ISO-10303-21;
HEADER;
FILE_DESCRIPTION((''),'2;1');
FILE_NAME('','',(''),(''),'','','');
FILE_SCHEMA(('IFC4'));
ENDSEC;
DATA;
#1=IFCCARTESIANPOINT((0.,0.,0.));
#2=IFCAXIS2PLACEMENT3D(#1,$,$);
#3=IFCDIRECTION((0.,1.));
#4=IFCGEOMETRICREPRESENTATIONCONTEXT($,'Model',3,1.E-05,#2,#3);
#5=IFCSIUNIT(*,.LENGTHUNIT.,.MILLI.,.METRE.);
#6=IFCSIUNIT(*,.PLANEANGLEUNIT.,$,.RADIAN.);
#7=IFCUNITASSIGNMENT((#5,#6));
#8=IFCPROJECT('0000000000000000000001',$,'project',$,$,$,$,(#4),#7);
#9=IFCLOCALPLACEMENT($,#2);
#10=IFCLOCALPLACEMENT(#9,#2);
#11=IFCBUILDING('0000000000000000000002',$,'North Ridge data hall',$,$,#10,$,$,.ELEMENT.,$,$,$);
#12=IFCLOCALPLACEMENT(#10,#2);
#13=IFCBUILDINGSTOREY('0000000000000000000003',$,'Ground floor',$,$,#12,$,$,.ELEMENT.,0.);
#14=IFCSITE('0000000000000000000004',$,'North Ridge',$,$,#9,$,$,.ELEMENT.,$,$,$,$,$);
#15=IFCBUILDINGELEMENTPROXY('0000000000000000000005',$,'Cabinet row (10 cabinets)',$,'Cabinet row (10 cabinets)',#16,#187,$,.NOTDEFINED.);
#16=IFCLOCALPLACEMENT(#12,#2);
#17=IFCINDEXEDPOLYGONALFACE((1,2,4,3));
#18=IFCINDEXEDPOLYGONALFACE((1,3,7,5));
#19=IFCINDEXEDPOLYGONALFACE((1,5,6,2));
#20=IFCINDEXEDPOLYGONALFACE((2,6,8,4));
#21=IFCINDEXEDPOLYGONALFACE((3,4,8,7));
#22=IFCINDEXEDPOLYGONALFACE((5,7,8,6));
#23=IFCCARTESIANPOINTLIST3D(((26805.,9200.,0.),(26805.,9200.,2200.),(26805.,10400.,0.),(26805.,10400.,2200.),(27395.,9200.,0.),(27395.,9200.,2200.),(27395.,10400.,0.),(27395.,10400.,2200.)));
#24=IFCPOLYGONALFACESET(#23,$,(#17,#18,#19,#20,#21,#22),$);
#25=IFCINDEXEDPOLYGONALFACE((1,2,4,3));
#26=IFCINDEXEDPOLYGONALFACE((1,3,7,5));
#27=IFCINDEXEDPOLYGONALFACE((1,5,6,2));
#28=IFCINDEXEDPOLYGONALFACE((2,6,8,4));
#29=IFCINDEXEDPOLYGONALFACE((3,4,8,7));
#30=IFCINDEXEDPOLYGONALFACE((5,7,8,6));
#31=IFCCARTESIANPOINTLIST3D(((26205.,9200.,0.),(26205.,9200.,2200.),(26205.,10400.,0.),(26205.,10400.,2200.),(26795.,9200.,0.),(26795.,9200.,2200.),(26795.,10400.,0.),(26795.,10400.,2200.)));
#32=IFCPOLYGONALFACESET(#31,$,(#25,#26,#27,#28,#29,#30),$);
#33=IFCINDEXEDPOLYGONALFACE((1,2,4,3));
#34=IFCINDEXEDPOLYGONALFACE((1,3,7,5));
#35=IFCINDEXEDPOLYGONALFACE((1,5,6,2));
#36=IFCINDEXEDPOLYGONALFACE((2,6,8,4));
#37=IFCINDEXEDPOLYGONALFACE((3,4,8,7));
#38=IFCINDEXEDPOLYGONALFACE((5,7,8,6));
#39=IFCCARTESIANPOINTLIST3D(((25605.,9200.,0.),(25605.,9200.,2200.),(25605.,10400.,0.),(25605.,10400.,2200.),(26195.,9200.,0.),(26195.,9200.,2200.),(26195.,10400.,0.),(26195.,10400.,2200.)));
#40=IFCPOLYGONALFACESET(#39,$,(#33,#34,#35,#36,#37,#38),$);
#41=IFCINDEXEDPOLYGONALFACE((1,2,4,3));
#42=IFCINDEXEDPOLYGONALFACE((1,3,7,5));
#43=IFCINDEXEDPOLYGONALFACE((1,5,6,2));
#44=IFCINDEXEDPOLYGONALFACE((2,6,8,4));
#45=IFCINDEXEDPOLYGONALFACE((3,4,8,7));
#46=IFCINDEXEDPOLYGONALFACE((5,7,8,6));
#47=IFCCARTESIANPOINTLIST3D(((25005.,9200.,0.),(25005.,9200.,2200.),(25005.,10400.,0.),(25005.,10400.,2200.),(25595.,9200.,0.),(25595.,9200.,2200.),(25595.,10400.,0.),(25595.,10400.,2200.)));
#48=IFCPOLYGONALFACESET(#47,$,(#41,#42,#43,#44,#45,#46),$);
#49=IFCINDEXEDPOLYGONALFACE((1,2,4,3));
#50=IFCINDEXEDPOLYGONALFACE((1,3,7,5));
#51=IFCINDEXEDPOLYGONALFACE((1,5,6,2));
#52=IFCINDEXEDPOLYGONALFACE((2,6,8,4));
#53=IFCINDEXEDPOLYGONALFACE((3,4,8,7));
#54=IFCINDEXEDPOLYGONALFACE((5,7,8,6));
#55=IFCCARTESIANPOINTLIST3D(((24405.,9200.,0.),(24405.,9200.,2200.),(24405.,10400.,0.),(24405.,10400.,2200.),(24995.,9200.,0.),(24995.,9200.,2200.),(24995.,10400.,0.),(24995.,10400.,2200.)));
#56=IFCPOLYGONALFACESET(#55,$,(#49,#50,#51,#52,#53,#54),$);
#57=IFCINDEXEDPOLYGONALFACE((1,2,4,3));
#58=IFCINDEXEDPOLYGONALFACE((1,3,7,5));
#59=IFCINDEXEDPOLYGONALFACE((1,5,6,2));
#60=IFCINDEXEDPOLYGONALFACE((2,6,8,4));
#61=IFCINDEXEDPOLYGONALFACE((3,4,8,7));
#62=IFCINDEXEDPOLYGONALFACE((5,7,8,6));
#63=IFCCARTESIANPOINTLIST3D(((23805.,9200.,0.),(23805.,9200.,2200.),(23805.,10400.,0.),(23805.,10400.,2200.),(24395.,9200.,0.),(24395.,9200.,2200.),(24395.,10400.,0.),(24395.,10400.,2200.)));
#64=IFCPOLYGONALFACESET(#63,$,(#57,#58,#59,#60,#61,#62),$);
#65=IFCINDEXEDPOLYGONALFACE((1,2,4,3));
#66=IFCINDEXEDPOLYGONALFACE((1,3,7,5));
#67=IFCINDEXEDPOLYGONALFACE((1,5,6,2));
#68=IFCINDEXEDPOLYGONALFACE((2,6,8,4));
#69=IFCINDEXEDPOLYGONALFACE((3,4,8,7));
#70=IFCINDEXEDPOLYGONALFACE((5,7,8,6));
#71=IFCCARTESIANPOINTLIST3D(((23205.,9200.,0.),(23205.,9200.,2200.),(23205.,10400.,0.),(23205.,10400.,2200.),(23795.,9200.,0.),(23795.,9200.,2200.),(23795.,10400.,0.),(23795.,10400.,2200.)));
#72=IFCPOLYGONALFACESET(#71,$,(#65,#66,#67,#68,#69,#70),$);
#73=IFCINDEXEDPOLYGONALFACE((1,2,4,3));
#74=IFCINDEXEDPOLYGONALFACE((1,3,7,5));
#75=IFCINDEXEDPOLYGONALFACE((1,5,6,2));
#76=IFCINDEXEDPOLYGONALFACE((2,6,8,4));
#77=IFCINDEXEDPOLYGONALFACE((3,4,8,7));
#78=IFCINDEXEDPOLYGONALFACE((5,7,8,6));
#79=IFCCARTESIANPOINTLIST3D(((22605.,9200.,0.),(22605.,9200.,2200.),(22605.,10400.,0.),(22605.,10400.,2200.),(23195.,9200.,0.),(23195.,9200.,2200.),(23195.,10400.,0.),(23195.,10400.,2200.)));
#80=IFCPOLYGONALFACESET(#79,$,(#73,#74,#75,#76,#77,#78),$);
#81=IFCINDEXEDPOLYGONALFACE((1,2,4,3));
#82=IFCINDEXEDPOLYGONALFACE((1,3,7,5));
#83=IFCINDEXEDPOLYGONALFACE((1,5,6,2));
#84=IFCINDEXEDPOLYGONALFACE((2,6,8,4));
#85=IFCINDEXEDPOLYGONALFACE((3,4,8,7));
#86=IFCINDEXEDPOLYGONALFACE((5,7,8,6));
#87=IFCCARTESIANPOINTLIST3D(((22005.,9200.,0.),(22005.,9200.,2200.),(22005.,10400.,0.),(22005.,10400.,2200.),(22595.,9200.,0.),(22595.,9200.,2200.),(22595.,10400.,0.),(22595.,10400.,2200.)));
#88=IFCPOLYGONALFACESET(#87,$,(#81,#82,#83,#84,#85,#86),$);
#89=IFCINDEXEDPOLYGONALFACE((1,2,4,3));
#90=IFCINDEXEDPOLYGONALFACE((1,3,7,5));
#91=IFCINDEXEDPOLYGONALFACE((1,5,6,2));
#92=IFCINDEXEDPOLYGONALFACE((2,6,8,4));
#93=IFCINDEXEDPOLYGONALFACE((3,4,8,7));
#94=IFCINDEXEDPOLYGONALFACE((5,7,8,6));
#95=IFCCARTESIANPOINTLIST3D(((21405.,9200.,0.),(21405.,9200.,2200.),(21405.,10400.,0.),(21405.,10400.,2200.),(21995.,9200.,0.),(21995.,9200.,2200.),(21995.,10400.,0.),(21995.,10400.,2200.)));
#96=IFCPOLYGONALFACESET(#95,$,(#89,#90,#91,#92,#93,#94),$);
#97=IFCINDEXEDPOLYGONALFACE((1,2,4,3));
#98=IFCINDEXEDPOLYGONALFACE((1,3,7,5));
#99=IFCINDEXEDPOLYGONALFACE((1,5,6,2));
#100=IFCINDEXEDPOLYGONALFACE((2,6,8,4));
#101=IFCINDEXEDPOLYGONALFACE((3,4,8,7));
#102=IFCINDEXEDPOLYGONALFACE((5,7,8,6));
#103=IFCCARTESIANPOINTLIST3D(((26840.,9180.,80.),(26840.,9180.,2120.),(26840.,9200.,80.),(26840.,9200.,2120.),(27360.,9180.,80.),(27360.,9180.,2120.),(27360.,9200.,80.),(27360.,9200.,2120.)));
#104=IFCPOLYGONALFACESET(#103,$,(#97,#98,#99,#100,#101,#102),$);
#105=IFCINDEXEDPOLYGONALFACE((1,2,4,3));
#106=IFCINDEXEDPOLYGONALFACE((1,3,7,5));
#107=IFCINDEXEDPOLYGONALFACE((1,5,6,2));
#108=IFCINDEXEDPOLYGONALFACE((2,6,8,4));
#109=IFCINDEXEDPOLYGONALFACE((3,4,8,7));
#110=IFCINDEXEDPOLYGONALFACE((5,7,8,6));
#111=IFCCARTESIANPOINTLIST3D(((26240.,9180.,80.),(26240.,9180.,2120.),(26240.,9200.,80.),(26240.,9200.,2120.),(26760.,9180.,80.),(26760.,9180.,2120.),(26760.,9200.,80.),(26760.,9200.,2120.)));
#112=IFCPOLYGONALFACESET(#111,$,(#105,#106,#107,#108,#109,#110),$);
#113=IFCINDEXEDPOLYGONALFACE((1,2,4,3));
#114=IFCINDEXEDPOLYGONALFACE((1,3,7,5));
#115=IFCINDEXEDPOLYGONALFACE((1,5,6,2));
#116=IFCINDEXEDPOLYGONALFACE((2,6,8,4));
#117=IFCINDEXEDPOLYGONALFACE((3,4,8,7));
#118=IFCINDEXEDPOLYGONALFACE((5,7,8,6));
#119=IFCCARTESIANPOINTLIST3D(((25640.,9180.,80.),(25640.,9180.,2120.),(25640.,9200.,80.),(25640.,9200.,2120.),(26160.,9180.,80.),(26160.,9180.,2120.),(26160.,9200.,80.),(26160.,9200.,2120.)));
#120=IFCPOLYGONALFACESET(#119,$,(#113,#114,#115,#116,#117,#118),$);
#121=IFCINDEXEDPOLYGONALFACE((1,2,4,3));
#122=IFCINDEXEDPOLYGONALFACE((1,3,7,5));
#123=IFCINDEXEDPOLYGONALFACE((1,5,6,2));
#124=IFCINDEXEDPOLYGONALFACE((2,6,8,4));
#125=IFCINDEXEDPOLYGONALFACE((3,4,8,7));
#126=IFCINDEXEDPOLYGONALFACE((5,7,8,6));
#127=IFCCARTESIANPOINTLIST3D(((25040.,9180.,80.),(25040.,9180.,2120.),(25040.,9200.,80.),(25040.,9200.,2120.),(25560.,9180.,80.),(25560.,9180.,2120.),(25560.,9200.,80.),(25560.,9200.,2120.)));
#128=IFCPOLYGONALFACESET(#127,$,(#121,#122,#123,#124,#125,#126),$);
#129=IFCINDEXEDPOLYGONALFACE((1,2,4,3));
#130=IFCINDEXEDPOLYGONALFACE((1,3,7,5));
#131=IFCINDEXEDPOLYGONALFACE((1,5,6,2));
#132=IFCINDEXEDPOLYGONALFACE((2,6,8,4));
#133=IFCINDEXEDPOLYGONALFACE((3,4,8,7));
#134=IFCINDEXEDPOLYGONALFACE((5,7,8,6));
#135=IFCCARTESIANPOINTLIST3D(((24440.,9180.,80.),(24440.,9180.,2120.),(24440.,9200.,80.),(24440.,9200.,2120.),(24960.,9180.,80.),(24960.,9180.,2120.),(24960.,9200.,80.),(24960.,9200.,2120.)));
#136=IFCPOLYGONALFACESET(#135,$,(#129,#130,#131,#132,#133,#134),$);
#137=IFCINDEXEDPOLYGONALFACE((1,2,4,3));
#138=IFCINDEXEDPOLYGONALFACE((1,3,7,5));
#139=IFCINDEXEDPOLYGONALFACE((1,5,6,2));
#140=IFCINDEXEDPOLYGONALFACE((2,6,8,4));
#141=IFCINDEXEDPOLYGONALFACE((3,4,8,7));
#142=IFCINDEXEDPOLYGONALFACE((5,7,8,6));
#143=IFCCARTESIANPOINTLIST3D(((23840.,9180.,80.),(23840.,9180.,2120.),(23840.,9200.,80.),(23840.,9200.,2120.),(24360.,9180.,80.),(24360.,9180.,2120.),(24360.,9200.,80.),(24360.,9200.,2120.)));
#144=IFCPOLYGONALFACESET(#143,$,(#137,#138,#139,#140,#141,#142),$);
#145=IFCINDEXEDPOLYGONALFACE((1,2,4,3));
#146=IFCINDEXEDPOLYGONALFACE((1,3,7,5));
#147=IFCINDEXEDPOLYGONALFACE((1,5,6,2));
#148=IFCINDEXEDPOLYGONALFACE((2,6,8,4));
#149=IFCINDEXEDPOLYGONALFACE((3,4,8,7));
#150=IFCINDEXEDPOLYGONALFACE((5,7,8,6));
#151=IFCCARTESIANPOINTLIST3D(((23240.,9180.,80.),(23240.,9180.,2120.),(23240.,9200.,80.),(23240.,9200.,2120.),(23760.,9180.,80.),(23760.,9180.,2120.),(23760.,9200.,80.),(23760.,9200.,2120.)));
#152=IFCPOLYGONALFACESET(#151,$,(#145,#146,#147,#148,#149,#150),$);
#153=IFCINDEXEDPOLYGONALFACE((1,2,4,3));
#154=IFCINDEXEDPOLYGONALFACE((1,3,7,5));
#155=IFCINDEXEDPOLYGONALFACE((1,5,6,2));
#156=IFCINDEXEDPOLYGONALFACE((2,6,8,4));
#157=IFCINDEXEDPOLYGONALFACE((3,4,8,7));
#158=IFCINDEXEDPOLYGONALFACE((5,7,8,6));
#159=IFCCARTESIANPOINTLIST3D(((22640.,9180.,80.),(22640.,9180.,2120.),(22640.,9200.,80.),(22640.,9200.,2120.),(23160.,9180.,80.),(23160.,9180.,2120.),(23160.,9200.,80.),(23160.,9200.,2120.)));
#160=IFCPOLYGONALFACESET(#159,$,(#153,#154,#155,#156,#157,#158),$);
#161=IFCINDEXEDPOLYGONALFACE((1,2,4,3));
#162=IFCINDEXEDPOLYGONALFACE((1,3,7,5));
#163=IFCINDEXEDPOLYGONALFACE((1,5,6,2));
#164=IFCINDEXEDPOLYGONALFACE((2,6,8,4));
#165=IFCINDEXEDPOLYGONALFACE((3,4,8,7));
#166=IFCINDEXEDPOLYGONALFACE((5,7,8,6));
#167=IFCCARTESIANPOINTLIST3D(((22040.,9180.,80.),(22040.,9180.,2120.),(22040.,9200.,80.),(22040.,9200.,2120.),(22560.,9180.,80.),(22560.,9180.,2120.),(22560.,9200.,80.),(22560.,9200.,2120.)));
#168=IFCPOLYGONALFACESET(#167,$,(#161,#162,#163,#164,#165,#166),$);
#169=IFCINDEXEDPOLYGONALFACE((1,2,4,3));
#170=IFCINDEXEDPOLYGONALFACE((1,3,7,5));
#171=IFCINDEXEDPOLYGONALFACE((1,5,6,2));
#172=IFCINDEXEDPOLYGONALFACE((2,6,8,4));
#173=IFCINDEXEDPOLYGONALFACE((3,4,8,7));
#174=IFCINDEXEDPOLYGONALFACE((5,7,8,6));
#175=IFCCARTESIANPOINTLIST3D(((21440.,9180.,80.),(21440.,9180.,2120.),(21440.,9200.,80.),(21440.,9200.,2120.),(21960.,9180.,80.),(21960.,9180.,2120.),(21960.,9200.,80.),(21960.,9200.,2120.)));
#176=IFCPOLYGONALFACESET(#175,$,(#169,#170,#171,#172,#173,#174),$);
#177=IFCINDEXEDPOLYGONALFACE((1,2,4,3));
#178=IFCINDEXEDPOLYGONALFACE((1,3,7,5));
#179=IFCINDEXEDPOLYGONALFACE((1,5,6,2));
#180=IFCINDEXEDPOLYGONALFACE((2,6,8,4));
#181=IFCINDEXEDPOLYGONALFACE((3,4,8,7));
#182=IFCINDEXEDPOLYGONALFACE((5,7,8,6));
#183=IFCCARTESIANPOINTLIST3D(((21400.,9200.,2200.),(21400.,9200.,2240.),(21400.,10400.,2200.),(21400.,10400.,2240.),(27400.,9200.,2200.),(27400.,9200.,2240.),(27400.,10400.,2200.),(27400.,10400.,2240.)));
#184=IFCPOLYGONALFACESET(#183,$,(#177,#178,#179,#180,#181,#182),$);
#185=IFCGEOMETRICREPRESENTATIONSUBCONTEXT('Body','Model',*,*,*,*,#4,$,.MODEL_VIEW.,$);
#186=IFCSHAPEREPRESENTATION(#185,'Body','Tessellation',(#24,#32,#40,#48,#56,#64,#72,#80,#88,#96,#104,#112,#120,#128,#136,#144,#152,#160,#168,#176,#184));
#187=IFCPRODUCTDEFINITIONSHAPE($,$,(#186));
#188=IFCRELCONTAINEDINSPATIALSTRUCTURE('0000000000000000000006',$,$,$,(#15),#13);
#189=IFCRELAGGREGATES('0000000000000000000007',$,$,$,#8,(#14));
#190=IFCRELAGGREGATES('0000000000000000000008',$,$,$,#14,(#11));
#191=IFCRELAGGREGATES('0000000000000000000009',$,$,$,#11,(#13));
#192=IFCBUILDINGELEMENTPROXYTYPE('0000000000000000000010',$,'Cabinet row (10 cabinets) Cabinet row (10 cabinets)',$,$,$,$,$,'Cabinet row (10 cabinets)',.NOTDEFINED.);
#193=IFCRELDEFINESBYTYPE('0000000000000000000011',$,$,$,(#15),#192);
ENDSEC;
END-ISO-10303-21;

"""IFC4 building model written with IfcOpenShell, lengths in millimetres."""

from ifc_helpers import new_model, si_unit, direction, frame, origin, place, context, subcontext, project, spatial, polyline, outline, extrude, source, transform, mapped, type_object, type_shapes, element, save


model = new_model("IFC4")

# Units and contexts
model_context = context("Model", 3, precision=1e-05, world=origin(), true_north=direction((0.0, 1.0)))
body_context = subcontext(model_context, "Body", "Model", "MODEL_VIEW")
ifc_project = project(units=[si_unit("LENGTHUNIT", "METRE", prefix="MILLI"), si_unit("PLANEANGLEUNIT", "RADIAN")], contexts=[model_context])

# Site, building, storey
site_placement = place(None, origin())
site = spatial("IfcSite", under=ifc_project, at=site_placement, Name="North Ridge", CompositionType="ELEMENT")
building_placement = place(site_placement, origin())
building = spatial("IfcBuilding", under=site, at=building_placement, Name="North Ridge data hall", CompositionType="ELEMENT")
storey_placement = place(building_placement, origin())
storey = spatial("IfcBuildingStorey", under=building, at=storey_placement, Name="Ground floor", CompositionType="ELEMENT", Elevation=0.0)

# Building element proxy
building_element_proxy_type_1 = type_object("IfcBuildingElementProxyType", Name="Cabinet row (10 cabinets) Cabinet row (10 cabinets)", ElementType="Cabinet row (10 cabinets)", PredefinedType="NOTDEFINED")
shared_shape_1 = source(origin(), body_context, "Body", "SweptSolid", [
    extrude(outline(polyline([(5.0, 0.0), (595.0, 0.0), (595.0, 1200.0), (5.0, 1200.0), (5.0, 0.0)])), origin(), (0.0, 0.0, 1.0), 2200.0),
    extrude(outline(polyline([(605.0, 0.0), (1195.0, 0.0), (1195.0, 1200.0), (605.0, 1200.0), (605.0, 0.0)])), origin(), (0.0, 0.0, 1.0), 2200.0),
    extrude(outline(polyline([(1205.0, 0.0), (1795.0, 0.0), (1795.0, 1200.0), (1205.0, 1200.0), (1205.0, 0.0)])), origin(), (0.0, 0.0, 1.0), 2200.0),
    extrude(outline(polyline([(1805.0, 0.0), (2395.0, 0.0), (2395.0, 1200.0), (1805.0, 1200.0), (1805.0, 0.0)])), origin(), (0.0, 0.0, 1.0), 2200.0),
    extrude(outline(polyline([(2405.0, 0.0), (2995.0, 0.0), (2995.0, 1200.0), (2405.0, 1200.0), (2405.0, 0.0)])), origin(), (0.0, 0.0, 1.0), 2200.0),
    extrude(outline(polyline([(3005.0, 0.0), (3595.0, 0.0), (3595.0, 1200.0), (3005.0, 1200.0), (3005.0, 0.0)])), origin(), (0.0, 0.0, 1.0), 2200.0),
    extrude(outline(polyline([(3605.0, 0.0), (4195.0, 0.0), (4195.0, 1200.0), (3605.0, 1200.0), (3605.0, 0.0)])), origin(), (0.0, 0.0, 1.0), 2200.0),
    extrude(outline(polyline([(4205.0, 0.0), (4795.0, 0.0), (4795.0, 1200.0), (4205.0, 1200.0), (4205.0, 0.0)])), origin(), (0.0, 0.0, 1.0), 2200.0),
    extrude(outline(polyline([(4805.0, 0.0), (5395.0, 0.0), (5395.0, 1200.0), (4805.0, 1200.0), (4805.0, 0.0)])), origin(), (0.0, 0.0, 1.0), 2200.0),
    extrude(outline(polyline([(5405.0, 0.0), (5995.0, 0.0), (5995.0, 1200.0), (5405.0, 1200.0), (5405.0, 0.0)])), origin(), (0.0, 0.0, 1.0), 2200.0),
    extrude(outline(polyline([(40.0, 1200.0), (560.0, 1200.0), (560.0, 1220.0), (40.0, 1220.0), (40.0, 1200.0)])), frame((0.0, 0.0, 80.0)), (0.0, 0.0, 1.0), 2040.0),
    extrude(outline(polyline([(640.0, 1200.0), (1160.0, 1200.0), (1160.0, 1220.0), (640.0, 1220.0), (640.0, 1200.0)])), frame((0.0, 0.0, 80.0)), (0.0, 0.0, 1.0), 2040.0),
    extrude(outline(polyline([(1240.0, 1200.0), (1760.0, 1200.0), (1760.0, 1220.0), (1240.0, 1220.0), (1240.0, 1200.0)])), frame((0.0, 0.0, 80.0)), (0.0, 0.0, 1.0), 2040.0),
    extrude(outline(polyline([(1840.0, 1200.0), (2360.0, 1200.0), (2360.0, 1220.0), (1840.0, 1220.0), (1840.0, 1200.0)])), frame((0.0, 0.0, 80.0)), (0.0, 0.0, 1.0), 2040.0),
    extrude(outline(polyline([(2440.0, 1200.0), (2960.0, 1200.0), (2960.0, 1220.0), (2440.0, 1220.0), (2440.0, 1200.0)])), frame((0.0, 0.0, 80.0)), (0.0, 0.0, 1.0), 2040.0),
    extrude(outline(polyline([(3040.0, 1200.0), (3560.0, 1200.0), (3560.0, 1220.0), (3040.0, 1220.0), (3040.0, 1200.0)])), frame((0.0, 0.0, 80.0)), (0.0, 0.0, 1.0), 2040.0),
    extrude(outline(polyline([(3640.0, 1200.0), (4160.0, 1200.0), (4160.0, 1220.0), (3640.0, 1220.0), (3640.0, 1200.0)])), frame((0.0, 0.0, 80.0)), (0.0, 0.0, 1.0), 2040.0),
    extrude(outline(polyline([(4240.0, 1200.0), (4760.0, 1200.0), (4760.0, 1220.0), (4240.0, 1220.0), (4240.0, 1200.0)])), frame((0.0, 0.0, 80.0)), (0.0, 0.0, 1.0), 2040.0),
    extrude(outline(polyline([(4840.0, 1200.0), (5360.0, 1200.0), (5360.0, 1220.0), (4840.0, 1220.0), (4840.0, 1200.0)])), frame((0.0, 0.0, 80.0)), (0.0, 0.0, 1.0), 2040.0),
    extrude(outline(polyline([(5440.0, 1200.0), (5960.0, 1200.0), (5960.0, 1220.0), (5440.0, 1220.0), (5440.0, 1200.0)])), frame((0.0, 0.0, 80.0)), (0.0, 0.0, 1.0), 2040.0),
    extrude(outline(polyline([(0.0, 0.0), (6000.0, 0.0), (6000.0, 1200.0), (0.0, 1200.0), (0.0, 0.0)])), frame((0.0, 0.0, 2200.0)), (0.0, 0.0, 1.0), 40.0),
])
type_shapes(building_element_proxy_type_1, [shared_shape_1])
for number, where, z_axis, x_axis, name in (
    (1, (27400.0, 10400.0, 0.0), (0.0, 0.0, 1.0), (-1.0, 0.0, 0.0), "Cabinet row (10 cabinets)"),
):
    element("IfcBuildingElementProxy", number, at=place(storey_placement, frame(where, z_axis=z_axis, x_axis=x_axis)), inside=storey, type_object=building_element_proxy_type_1, Name=name, ObjectType="Cabinet row (10 cabinets)", PredefinedType="NOTDEFINED", context=body_context, shape_type="MappedRepresentation", body=[
        mapped(shared_shape_1, transform((0.0, 0.0, 0.0))),
    ])

save(model, "model.ifc")
